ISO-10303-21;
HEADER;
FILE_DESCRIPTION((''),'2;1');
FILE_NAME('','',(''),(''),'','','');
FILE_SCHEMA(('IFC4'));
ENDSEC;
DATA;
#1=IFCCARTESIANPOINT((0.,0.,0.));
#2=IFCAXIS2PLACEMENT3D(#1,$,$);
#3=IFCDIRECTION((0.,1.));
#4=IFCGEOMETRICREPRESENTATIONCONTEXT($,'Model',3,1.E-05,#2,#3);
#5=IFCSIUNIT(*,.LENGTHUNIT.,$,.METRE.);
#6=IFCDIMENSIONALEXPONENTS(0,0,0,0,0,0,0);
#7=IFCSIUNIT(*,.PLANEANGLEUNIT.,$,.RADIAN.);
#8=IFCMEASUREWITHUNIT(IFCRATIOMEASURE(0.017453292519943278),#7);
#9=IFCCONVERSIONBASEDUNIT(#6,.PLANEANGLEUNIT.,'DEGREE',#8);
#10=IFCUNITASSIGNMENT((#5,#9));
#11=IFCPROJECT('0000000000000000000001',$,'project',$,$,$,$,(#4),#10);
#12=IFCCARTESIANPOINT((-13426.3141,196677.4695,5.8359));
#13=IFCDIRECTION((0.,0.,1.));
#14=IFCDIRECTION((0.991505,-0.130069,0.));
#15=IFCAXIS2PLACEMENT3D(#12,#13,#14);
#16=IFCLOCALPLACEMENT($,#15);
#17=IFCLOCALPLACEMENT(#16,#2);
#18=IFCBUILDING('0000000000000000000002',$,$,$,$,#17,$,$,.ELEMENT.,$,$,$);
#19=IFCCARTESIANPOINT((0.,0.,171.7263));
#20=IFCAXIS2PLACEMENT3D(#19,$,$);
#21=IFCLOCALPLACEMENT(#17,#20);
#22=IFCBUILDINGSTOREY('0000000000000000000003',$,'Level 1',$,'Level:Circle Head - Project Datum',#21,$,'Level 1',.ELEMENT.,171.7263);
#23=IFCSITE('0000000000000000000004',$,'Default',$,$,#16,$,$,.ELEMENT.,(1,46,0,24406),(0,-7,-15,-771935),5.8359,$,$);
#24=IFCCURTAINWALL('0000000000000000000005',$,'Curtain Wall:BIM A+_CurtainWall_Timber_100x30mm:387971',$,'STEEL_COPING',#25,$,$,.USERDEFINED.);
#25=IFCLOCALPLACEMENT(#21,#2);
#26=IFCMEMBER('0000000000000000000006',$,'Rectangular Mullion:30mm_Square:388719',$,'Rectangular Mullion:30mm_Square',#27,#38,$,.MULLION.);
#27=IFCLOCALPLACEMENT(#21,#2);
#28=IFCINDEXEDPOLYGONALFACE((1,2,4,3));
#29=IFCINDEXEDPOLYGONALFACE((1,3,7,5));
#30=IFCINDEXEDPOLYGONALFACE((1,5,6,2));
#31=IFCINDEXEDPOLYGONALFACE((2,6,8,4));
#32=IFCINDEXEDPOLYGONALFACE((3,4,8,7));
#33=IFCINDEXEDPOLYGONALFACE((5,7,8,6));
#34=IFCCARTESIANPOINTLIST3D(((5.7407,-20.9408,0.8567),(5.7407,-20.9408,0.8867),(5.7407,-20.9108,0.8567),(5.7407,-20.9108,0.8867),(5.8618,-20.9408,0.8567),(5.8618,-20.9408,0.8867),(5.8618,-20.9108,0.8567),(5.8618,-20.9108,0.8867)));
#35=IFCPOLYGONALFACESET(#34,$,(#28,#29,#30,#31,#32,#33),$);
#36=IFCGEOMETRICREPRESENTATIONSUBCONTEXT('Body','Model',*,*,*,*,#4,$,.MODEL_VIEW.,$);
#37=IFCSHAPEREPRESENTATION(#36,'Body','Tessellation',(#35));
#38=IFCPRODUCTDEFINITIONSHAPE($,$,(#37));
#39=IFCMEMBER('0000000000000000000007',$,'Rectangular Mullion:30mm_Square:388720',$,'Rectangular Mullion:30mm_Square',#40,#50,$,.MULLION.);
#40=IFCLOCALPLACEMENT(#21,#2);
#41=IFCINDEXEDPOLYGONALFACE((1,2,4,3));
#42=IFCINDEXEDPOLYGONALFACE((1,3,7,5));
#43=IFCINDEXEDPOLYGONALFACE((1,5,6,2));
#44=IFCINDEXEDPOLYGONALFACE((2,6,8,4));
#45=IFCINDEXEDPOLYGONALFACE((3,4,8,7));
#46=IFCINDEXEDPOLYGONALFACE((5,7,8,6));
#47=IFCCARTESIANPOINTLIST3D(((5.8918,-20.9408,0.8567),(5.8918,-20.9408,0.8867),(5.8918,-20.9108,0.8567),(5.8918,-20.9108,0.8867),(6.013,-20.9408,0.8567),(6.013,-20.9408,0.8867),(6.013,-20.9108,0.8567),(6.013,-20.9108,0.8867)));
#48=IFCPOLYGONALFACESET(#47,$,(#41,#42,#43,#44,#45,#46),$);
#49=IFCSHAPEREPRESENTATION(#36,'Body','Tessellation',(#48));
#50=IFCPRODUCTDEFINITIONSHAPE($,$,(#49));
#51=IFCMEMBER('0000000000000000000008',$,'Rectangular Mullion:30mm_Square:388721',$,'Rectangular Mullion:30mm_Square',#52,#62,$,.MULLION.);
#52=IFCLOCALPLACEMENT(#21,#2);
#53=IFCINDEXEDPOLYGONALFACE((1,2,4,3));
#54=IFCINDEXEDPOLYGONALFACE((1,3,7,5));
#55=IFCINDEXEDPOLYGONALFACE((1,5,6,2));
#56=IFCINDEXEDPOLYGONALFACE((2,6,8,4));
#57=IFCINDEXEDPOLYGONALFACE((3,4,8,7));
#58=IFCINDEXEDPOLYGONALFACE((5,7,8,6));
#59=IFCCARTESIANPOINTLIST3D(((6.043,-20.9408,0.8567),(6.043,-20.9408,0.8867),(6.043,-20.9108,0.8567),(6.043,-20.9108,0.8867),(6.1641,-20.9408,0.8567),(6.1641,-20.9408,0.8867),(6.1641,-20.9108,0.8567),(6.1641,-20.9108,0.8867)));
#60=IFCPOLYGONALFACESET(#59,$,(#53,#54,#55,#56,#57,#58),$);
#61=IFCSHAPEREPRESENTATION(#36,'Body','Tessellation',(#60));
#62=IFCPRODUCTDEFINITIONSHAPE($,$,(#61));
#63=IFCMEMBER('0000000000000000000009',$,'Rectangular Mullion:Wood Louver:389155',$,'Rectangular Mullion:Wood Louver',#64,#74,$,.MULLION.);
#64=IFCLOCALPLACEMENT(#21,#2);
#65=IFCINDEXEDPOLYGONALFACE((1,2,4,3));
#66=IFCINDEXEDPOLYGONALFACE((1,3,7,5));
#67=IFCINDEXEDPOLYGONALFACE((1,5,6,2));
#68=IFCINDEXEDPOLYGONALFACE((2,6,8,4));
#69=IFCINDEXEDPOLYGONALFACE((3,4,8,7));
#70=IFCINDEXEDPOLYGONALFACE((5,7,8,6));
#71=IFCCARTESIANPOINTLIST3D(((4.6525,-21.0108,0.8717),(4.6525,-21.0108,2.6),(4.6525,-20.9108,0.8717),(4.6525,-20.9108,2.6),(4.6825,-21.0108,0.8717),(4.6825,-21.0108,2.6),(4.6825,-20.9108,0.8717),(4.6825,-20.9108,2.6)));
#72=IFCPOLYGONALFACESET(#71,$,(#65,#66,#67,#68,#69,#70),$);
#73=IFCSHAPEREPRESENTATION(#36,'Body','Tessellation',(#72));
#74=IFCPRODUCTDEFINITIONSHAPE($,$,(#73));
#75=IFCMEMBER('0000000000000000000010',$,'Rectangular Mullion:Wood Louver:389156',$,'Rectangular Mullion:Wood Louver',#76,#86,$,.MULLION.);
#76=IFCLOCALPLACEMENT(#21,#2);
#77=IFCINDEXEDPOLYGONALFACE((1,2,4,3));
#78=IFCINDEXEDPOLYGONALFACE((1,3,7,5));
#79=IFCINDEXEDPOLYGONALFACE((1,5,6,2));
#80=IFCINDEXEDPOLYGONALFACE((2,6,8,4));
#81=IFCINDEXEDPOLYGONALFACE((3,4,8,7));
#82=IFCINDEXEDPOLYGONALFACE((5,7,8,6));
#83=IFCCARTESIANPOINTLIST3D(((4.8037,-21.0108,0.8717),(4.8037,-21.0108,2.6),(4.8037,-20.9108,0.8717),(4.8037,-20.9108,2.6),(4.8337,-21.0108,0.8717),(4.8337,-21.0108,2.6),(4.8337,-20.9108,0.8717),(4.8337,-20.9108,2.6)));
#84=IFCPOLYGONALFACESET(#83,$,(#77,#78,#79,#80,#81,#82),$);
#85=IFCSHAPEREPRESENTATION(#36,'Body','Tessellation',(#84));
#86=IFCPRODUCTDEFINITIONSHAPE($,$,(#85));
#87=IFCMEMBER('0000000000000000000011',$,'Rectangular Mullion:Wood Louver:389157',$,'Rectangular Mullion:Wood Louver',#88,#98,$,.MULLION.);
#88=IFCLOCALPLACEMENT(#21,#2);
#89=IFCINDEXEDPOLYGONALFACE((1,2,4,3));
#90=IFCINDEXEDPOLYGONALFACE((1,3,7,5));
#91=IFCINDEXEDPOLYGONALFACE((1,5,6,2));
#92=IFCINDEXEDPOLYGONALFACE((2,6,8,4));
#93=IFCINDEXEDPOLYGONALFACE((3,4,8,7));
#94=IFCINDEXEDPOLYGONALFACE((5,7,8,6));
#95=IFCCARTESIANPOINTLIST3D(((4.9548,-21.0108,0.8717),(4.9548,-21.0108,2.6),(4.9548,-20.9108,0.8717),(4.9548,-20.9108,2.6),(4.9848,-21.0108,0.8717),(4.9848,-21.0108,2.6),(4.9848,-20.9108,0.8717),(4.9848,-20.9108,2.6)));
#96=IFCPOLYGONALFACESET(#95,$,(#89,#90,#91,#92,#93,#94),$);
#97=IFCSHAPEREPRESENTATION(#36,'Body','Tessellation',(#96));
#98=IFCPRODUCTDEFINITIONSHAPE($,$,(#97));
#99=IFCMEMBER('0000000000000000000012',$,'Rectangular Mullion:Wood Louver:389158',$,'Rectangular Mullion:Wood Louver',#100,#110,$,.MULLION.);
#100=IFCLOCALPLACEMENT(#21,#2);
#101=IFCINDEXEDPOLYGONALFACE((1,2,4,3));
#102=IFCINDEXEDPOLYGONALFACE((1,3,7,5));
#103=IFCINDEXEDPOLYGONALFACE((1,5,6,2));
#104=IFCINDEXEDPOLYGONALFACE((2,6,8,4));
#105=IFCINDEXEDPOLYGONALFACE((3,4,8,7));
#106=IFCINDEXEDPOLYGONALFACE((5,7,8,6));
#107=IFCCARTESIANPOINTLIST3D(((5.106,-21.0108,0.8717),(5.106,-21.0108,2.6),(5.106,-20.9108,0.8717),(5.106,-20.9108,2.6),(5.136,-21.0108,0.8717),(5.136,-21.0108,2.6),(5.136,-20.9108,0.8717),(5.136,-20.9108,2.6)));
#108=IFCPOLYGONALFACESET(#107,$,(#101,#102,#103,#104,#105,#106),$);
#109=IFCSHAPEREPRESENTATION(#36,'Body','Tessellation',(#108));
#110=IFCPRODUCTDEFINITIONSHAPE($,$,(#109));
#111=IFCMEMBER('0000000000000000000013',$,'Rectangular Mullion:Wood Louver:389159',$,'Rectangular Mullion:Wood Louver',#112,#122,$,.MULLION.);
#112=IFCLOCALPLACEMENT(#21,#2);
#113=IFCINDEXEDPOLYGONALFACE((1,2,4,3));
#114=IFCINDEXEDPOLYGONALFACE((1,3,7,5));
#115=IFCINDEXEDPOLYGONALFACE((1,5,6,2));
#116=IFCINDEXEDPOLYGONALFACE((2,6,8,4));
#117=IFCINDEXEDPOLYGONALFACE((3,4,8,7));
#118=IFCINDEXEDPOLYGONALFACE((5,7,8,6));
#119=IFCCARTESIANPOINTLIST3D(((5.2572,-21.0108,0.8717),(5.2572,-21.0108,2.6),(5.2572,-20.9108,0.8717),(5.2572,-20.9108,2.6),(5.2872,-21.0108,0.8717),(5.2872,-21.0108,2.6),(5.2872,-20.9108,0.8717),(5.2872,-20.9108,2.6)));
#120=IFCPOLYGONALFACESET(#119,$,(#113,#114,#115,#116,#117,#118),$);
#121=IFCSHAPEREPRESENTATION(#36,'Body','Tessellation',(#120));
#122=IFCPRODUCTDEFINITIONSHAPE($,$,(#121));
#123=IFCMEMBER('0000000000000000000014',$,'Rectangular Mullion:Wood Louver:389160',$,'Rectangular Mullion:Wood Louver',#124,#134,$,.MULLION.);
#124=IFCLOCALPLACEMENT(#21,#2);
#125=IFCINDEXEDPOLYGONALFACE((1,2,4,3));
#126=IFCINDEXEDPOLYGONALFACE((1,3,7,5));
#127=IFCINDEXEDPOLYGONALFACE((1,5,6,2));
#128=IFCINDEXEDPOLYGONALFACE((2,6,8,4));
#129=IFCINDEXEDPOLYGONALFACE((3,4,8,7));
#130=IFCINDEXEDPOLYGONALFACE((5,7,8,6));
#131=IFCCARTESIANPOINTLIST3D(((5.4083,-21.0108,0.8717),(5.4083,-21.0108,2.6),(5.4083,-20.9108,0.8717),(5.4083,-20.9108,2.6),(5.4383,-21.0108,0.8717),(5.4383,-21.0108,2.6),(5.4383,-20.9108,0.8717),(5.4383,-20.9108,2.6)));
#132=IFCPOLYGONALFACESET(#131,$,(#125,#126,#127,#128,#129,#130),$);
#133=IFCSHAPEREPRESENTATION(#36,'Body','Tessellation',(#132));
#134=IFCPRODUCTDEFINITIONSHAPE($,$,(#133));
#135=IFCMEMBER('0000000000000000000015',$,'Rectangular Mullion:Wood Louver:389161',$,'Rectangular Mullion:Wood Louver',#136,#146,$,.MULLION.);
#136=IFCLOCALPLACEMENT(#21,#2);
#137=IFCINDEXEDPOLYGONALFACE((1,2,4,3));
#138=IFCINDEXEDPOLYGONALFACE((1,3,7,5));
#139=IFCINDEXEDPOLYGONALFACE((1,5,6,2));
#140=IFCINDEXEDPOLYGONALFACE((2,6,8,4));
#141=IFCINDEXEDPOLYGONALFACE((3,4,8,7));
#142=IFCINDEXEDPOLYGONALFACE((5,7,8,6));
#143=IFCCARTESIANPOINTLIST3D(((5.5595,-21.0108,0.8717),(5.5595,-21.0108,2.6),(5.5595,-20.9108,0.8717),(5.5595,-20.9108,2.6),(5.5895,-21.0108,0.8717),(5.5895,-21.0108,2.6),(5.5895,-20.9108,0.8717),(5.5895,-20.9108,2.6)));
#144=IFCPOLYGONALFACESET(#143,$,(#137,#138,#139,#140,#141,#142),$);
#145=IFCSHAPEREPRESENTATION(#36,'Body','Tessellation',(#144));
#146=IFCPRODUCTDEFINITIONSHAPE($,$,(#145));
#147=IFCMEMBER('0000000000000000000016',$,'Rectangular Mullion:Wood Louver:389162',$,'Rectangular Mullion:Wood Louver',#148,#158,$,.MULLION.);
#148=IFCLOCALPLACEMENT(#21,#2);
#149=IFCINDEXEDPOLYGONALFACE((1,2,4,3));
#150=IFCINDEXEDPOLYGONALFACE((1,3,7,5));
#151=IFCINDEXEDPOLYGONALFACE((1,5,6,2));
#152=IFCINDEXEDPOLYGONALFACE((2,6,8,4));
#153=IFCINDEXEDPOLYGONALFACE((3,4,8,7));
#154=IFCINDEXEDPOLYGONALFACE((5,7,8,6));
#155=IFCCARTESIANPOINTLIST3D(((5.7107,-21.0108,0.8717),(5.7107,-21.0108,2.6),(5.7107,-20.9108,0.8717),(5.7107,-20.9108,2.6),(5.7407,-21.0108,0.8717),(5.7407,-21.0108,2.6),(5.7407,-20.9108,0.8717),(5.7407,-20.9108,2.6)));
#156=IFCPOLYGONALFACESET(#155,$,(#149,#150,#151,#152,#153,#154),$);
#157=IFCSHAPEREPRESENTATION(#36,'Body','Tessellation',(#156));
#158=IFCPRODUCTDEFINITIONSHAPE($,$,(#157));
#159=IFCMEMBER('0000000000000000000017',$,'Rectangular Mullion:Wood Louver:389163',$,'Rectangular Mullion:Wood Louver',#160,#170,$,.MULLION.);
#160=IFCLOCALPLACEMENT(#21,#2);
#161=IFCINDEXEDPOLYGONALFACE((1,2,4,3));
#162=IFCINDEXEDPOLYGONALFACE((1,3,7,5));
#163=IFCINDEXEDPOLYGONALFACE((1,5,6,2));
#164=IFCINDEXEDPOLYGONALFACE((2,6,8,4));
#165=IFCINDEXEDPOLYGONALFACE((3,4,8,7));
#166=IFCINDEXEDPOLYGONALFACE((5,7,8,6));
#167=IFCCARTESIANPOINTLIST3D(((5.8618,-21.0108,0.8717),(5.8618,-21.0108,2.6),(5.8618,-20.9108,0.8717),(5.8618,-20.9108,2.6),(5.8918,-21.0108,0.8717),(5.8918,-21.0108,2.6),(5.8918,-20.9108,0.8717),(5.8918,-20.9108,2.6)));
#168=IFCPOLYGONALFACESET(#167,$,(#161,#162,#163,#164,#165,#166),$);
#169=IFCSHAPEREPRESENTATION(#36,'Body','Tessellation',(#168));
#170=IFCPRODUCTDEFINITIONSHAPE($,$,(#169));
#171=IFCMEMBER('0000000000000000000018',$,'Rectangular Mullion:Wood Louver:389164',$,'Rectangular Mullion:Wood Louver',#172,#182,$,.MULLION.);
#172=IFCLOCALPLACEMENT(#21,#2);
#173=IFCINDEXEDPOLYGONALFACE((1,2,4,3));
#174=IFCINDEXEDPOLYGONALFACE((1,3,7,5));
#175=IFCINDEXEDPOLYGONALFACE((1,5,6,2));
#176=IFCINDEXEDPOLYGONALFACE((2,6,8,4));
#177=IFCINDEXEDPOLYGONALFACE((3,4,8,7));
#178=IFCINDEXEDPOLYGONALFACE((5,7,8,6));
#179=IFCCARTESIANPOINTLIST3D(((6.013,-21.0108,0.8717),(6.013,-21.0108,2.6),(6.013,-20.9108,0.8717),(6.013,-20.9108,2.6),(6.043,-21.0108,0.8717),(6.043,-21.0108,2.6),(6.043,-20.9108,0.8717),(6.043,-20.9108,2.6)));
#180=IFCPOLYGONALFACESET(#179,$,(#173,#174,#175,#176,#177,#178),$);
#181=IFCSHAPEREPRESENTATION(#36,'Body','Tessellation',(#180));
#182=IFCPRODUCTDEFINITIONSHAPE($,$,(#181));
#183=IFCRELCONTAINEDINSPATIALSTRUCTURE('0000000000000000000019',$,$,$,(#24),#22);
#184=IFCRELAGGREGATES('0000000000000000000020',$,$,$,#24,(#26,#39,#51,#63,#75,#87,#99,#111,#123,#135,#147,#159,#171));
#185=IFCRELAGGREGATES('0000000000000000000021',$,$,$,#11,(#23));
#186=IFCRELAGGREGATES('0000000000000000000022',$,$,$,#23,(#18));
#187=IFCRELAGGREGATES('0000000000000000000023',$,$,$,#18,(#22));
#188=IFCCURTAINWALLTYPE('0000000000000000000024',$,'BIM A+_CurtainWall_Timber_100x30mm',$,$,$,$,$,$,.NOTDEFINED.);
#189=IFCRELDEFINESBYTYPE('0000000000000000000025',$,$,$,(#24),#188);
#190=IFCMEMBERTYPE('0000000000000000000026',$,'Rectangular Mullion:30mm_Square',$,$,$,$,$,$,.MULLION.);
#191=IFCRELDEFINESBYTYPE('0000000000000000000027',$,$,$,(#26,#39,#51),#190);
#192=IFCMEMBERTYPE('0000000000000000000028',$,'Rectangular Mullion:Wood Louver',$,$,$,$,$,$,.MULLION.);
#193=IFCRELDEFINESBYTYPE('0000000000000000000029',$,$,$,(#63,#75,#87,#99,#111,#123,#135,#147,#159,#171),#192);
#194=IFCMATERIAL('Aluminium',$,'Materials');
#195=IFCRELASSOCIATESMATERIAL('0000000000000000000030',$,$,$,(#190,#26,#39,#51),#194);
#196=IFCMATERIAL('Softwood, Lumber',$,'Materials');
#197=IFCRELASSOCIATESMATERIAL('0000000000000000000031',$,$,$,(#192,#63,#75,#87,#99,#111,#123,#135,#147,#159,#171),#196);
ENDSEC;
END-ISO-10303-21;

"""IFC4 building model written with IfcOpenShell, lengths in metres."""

from ifc_helpers import new_model, entity, si_unit, converted_unit, direction, frame, origin, place, context, subcontext, project, spatial, indexed_curve, outline, extrude, source, transform, mapped, material, type_object, type_shapes, element, aggregate, save


model = new_model("IFC4")

# Units and contexts
model_context = context("Model", 3, precision=1e-05, world=origin(), true_north=direction((0.0, 1.0)))
body_context = subcontext(model_context, "Body", "Model", "MODEL_VIEW")
ifc_project = project(units=[si_unit("LENGTHUNIT", "METRE"), converted_unit("PLANEANGLEUNIT", "DEGREE", entity("IfcRatioMeasure", 0.017453292519943278), si_unit("PLANEANGLEUNIT", "RADIAN"), dimensions=[0, 0, 0, 0, 0, 0, 0])], contexts=[model_context])

# Site, building, storey
site_placement = place(None, frame((-13426.3141, 196677.4695, 5.8359), z_axis=(0.0, 0.0, 1.0), x_axis=(0.991505, -0.130069, 0.0)))
site = spatial("IfcSite", under=ifc_project, at=site_placement, Name="Default", CompositionType="ELEMENT", RefLatitude=(1, 46, 0, 24406), RefLongitude=(0, -7, -15, -771935), RefElevation=5.8359)
building_placement = place(site_placement, origin())
building = spatial("IfcBuilding", under=site, at=building_placement, CompositionType="ELEMENT")
storey_placement = place(building_placement, frame((0.0, 0.0, 171.7263)))
storey = spatial("IfcBuildingStorey", under=building, at=storey_placement, Name="Level 1", ObjectType="Level:Circle Head - Project Datum", LongName="Level 1", CompositionType="ELEMENT", Elevation=171.7263)

# Shared definitions
ifc_material_1 = material(Name="Aluminium", Category="Materials")

# Curtain wall, members
curtain_wall_type_1 = type_object("IfcCurtainWallType", Name="BIM A+_CurtainWall_Timber_100x30mm", PredefinedType="NOTDEFINED")
curtain_wall_1_placement = place(storey_placement, frame((0.0, 0.0, -171.7263)))
curtain_wall_1 = element("IfcCurtainWall", 1, at=curtain_wall_1_placement, inside=storey, type_object=curtain_wall_type_1, Name="Curtain Wall:BIM A+_CurtainWall_Timber_100x30mm:387971", ObjectType="STEEL_COPING", PredefinedType="USERDEFINED")
member_type_1 = type_object("IfcMemberType", Name="Rectangular Mullion:30mm_Square", PredefinedType="MULLION", material=ifc_material_1)
shared_shape_1 = source(origin(), body_context, "Body", "SweptSolid", [
    extrude(outline(indexed_curve([(-0.015, -0.015), (0.015, -0.015), (0.015, 0.015), (-0.015, 0.015), (-0.015, -0.015)], self_intersect=False)), frame((0.0, 0.0, -0.1212), z_axis=(0.0, 0.0, 1.0), x_axis=(0.0, -1.0, 0.0)), (0.0, 0.0, 1.0), 0.1212),
])
type_shapes(member_type_1, [shared_shape_1])
member_1_placement = place(curtain_wall_1_placement, frame((5.8618, -20.9258, 172.598), z_axis=(1.0, 0.0, 0.0), x_axis=(0.0, 0.0, 1.0)))
member_1 = element("IfcMember", 2, at=member_1_placement, type_object=member_type_1, material=ifc_material_1, Name="Rectangular Mullion:30mm_Square:388719", ObjectType="Rectangular Mullion:30mm_Square", PredefinedType="MULLION", context=body_context, shape_type="MappedRepresentation", body=[
    mapped(shared_shape_1, transform((0.0, 0.0, 0.0), scale=1.0)),
])
member_2_placement = place(curtain_wall_1_placement, frame((6.013, -20.9258, 172.598), z_axis=(1.0, 0.0, 0.0), x_axis=(0.0, 0.0, 1.0)))
member_2 = element("IfcMember", 3, at=member_2_placement, type_object=member_type_1, material=ifc_material_1, Name="Rectangular Mullion:30mm_Square:388720", ObjectType="Rectangular Mullion:30mm_Square", PredefinedType="MULLION", context=body_context, shape_type="MappedRepresentation", body=[
    mapped(shared_shape_1, transform((0.0, 0.0, 0.0), scale=1.0)),
])
member_3_placement = place(curtain_wall_1_placement, frame((6.1641, -20.9258, 172.598), z_axis=(1.0, 0.0, 0.0), x_axis=(0.0, 0.0, 1.0)))
member_3 = element("IfcMember", 4, at=member_3_placement, type_object=member_type_1, material=ifc_material_1, Name="Rectangular Mullion:30mm_Square:388721", ObjectType="Rectangular Mullion:30mm_Square", PredefinedType="MULLION", context=body_context, shape_type="MappedRepresentation", body=[
    mapped(shared_shape_1, transform((0.0, 0.0, 0.0), scale=1.0)),
])
ifc_material_2 = material(Name="Softwood, Lumber", Category="Materials")
member_type_2 = type_object("IfcMemberType", Name="Rectangular Mullion:Wood Louver", PredefinedType="MULLION", material=ifc_material_2)
shared_shape_2 = source(origin(), body_context, "Body", "SweptSolid", [
    extrude(outline(indexed_curve([(-0.05, -0.015), (0.05, -0.015), (0.05, 0.015), (-0.05, 0.015), (-0.05, -0.015)], self_intersect=False)), frame((0.0, 0.035, -1.7283), z_axis=(0.0, 0.0, 1.0), x_axis=(0.0, -1.0, 0.0)), (0.0, 0.0, 1.0), 1.7283),
])
type_shapes(member_type_2, [shared_shape_2])
member_4_placement = place(curtain_wall_1_placement, frame((4.6675, -20.9258, 172.598), z_axis=(0.0, 0.0, -1.0), x_axis=(1.0, 0.0, 0.0)))
member_4 = element("IfcMember", 5, at=member_4_placement, type_object=member_type_2, material=ifc_material_2, Name="Rectangular Mullion:Wood Louver:389155", ObjectType="Rectangular Mullion:Wood Louver", PredefinedType="MULLION", context=body_context, shape_type="MappedRepresentation", body=[
    mapped(shared_shape_2, transform((0.0, 0.0, 0.0), scale=1.0)),
])
member_5_placement = place(curtain_wall_1_placement, frame((4.8187, -20.9258, 172.598), z_axis=(0.0, 0.0, -1.0), x_axis=(1.0, 0.0, 0.0)))
member_5 = element("IfcMember", 6, at=member_5_placement, type_object=member_type_2, material=ifc_material_2, Name="Rectangular Mullion:Wood Louver:389156", ObjectType="Rectangular Mullion:Wood Louver", PredefinedType="MULLION", context=body_context, shape_type="MappedRepresentation", body=[
    mapped(shared_shape_2, transform((0.0, 0.0, 0.0), scale=1.0)),
])
member_6_placement = place(curtain_wall_1_placement, frame((4.9698, -20.9258, 172.598), z_axis=(0.0, 0.0, -1.0), x_axis=(1.0, 0.0, 0.0)))
member_6 = element("IfcMember", 7, at=member_6_placement, type_object=member_type_2, material=ifc_material_2, Name="Rectangular Mullion:Wood Louver:389157", ObjectType="Rectangular Mullion:Wood Louver", PredefinedType="MULLION", context=body_context, shape_type="MappedRepresentation", body=[
    mapped(shared_shape_2, transform((0.0, 0.0, 0.0), scale=1.0)),
])
member_7_placement = place(curtain_wall_1_placement, frame((5.121, -20.9258, 172.598), z_axis=(0.0, 0.0, -1.0), x_axis=(1.0, 0.0, 0.0)))
member_7 = element("IfcMember", 8, at=member_7_placement, type_object=member_type_2, material=ifc_material_2, Name="Rectangular Mullion:Wood Louver:389158", ObjectType="Rectangular Mullion:Wood Louver", PredefinedType="MULLION", context=body_context, shape_type="MappedRepresentation", body=[
    mapped(shared_shape_2, transform((0.0, 0.0, 0.0), scale=1.0)),
])
member_8_placement = place(curtain_wall_1_placement, frame((5.2722, -20.9258, 172.598), z_axis=(0.0, 0.0, -1.0), x_axis=(1.0, 0.0, 0.0)))
member_8 = element("IfcMember", 9, at=member_8_placement, type_object=member_type_2, material=ifc_material_2, Name="Rectangular Mullion:Wood Louver:389159", ObjectType="Rectangular Mullion:Wood Louver", PredefinedType="MULLION", context=body_context, shape_type="MappedRepresentation", body=[
    mapped(shared_shape_2, transform((0.0, 0.0, 0.0), scale=1.0)),
])
member_9_placement = place(curtain_wall_1_placement, frame((5.4233, -20.9258, 172.598), z_axis=(0.0, 0.0, -1.0), x_axis=(1.0, 0.0, 0.0)))
member_9 = element("IfcMember", 10, at=member_9_placement, type_object=member_type_2, material=ifc_material_2, Name="Rectangular Mullion:Wood Louver:389160", ObjectType="Rectangular Mullion:Wood Louver", PredefinedType="MULLION", context=body_context, shape_type="MappedRepresentation", body=[
    mapped(shared_shape_2, transform((0.0, 0.0, 0.0), scale=1.0)),
])
member_10_placement = place(curtain_wall_1_placement, frame((5.5745, -20.9258, 172.598), z_axis=(0.0, 0.0, -1.0), x_axis=(1.0, 0.0, 0.0)))
member_10 = element("IfcMember", 11, at=member_10_placement, type_object=member_type_2, material=ifc_material_2, Name="Rectangular Mullion:Wood Louver:389161", ObjectType="Rectangular Mullion:Wood Louver", PredefinedType="MULLION", context=body_context, shape_type="MappedRepresentation", body=[
    mapped(shared_shape_2, transform((0.0, 0.0, 0.0), scale=1.0)),
])
member_11_placement = place(curtain_wall_1_placement, frame((5.7257, -20.9258, 172.598), z_axis=(0.0, 0.0, -1.0), x_axis=(1.0, 0.0, 0.0)))
member_11 = element("IfcMember", 12, at=member_11_placement, type_object=member_type_2, material=ifc_material_2, Name="Rectangular Mullion:Wood Louver:389162", ObjectType="Rectangular Mullion:Wood Louver", PredefinedType="MULLION", context=body_context, shape_type="MappedRepresentation", body=[
    mapped(shared_shape_2, transform((0.0, 0.0, 0.0), scale=1.0)),
])
member_12_placement = place(curtain_wall_1_placement, frame((5.8768, -20.9258, 172.598), z_axis=(0.0, 0.0, -1.0), x_axis=(1.0, 0.0, 0.0)))
member_12 = element("IfcMember", 13, at=member_12_placement, type_object=member_type_2, material=ifc_material_2, Name="Rectangular Mullion:Wood Louver:389163", ObjectType="Rectangular Mullion:Wood Louver", PredefinedType="MULLION", context=body_context, shape_type="MappedRepresentation", body=[
    mapped(shared_shape_2, transform((0.0, 0.0, 0.0), scale=1.0)),
])
member_13_placement = place(curtain_wall_1_placement, frame((6.028, -20.9258, 172.598), z_axis=(0.0, 0.0, -1.0), x_axis=(1.0, 0.0, 0.0)))
member_13 = element("IfcMember", 14, at=member_13_placement, type_object=member_type_2, material=ifc_material_2, Name="Rectangular Mullion:Wood Louver:389164", ObjectType="Rectangular Mullion:Wood Louver", PredefinedType="MULLION", context=body_context, shape_type="MappedRepresentation", body=[
    mapped(shared_shape_2, transform((0.0, 0.0, 0.0), scale=1.0)),
])

aggregate(curtain_wall_1, [member_1, member_2, member_3, member_4, member_5, member_6, member_7, member_8, member_9, member_10, member_11, member_12, member_13])

save(model, "model.ifc")
